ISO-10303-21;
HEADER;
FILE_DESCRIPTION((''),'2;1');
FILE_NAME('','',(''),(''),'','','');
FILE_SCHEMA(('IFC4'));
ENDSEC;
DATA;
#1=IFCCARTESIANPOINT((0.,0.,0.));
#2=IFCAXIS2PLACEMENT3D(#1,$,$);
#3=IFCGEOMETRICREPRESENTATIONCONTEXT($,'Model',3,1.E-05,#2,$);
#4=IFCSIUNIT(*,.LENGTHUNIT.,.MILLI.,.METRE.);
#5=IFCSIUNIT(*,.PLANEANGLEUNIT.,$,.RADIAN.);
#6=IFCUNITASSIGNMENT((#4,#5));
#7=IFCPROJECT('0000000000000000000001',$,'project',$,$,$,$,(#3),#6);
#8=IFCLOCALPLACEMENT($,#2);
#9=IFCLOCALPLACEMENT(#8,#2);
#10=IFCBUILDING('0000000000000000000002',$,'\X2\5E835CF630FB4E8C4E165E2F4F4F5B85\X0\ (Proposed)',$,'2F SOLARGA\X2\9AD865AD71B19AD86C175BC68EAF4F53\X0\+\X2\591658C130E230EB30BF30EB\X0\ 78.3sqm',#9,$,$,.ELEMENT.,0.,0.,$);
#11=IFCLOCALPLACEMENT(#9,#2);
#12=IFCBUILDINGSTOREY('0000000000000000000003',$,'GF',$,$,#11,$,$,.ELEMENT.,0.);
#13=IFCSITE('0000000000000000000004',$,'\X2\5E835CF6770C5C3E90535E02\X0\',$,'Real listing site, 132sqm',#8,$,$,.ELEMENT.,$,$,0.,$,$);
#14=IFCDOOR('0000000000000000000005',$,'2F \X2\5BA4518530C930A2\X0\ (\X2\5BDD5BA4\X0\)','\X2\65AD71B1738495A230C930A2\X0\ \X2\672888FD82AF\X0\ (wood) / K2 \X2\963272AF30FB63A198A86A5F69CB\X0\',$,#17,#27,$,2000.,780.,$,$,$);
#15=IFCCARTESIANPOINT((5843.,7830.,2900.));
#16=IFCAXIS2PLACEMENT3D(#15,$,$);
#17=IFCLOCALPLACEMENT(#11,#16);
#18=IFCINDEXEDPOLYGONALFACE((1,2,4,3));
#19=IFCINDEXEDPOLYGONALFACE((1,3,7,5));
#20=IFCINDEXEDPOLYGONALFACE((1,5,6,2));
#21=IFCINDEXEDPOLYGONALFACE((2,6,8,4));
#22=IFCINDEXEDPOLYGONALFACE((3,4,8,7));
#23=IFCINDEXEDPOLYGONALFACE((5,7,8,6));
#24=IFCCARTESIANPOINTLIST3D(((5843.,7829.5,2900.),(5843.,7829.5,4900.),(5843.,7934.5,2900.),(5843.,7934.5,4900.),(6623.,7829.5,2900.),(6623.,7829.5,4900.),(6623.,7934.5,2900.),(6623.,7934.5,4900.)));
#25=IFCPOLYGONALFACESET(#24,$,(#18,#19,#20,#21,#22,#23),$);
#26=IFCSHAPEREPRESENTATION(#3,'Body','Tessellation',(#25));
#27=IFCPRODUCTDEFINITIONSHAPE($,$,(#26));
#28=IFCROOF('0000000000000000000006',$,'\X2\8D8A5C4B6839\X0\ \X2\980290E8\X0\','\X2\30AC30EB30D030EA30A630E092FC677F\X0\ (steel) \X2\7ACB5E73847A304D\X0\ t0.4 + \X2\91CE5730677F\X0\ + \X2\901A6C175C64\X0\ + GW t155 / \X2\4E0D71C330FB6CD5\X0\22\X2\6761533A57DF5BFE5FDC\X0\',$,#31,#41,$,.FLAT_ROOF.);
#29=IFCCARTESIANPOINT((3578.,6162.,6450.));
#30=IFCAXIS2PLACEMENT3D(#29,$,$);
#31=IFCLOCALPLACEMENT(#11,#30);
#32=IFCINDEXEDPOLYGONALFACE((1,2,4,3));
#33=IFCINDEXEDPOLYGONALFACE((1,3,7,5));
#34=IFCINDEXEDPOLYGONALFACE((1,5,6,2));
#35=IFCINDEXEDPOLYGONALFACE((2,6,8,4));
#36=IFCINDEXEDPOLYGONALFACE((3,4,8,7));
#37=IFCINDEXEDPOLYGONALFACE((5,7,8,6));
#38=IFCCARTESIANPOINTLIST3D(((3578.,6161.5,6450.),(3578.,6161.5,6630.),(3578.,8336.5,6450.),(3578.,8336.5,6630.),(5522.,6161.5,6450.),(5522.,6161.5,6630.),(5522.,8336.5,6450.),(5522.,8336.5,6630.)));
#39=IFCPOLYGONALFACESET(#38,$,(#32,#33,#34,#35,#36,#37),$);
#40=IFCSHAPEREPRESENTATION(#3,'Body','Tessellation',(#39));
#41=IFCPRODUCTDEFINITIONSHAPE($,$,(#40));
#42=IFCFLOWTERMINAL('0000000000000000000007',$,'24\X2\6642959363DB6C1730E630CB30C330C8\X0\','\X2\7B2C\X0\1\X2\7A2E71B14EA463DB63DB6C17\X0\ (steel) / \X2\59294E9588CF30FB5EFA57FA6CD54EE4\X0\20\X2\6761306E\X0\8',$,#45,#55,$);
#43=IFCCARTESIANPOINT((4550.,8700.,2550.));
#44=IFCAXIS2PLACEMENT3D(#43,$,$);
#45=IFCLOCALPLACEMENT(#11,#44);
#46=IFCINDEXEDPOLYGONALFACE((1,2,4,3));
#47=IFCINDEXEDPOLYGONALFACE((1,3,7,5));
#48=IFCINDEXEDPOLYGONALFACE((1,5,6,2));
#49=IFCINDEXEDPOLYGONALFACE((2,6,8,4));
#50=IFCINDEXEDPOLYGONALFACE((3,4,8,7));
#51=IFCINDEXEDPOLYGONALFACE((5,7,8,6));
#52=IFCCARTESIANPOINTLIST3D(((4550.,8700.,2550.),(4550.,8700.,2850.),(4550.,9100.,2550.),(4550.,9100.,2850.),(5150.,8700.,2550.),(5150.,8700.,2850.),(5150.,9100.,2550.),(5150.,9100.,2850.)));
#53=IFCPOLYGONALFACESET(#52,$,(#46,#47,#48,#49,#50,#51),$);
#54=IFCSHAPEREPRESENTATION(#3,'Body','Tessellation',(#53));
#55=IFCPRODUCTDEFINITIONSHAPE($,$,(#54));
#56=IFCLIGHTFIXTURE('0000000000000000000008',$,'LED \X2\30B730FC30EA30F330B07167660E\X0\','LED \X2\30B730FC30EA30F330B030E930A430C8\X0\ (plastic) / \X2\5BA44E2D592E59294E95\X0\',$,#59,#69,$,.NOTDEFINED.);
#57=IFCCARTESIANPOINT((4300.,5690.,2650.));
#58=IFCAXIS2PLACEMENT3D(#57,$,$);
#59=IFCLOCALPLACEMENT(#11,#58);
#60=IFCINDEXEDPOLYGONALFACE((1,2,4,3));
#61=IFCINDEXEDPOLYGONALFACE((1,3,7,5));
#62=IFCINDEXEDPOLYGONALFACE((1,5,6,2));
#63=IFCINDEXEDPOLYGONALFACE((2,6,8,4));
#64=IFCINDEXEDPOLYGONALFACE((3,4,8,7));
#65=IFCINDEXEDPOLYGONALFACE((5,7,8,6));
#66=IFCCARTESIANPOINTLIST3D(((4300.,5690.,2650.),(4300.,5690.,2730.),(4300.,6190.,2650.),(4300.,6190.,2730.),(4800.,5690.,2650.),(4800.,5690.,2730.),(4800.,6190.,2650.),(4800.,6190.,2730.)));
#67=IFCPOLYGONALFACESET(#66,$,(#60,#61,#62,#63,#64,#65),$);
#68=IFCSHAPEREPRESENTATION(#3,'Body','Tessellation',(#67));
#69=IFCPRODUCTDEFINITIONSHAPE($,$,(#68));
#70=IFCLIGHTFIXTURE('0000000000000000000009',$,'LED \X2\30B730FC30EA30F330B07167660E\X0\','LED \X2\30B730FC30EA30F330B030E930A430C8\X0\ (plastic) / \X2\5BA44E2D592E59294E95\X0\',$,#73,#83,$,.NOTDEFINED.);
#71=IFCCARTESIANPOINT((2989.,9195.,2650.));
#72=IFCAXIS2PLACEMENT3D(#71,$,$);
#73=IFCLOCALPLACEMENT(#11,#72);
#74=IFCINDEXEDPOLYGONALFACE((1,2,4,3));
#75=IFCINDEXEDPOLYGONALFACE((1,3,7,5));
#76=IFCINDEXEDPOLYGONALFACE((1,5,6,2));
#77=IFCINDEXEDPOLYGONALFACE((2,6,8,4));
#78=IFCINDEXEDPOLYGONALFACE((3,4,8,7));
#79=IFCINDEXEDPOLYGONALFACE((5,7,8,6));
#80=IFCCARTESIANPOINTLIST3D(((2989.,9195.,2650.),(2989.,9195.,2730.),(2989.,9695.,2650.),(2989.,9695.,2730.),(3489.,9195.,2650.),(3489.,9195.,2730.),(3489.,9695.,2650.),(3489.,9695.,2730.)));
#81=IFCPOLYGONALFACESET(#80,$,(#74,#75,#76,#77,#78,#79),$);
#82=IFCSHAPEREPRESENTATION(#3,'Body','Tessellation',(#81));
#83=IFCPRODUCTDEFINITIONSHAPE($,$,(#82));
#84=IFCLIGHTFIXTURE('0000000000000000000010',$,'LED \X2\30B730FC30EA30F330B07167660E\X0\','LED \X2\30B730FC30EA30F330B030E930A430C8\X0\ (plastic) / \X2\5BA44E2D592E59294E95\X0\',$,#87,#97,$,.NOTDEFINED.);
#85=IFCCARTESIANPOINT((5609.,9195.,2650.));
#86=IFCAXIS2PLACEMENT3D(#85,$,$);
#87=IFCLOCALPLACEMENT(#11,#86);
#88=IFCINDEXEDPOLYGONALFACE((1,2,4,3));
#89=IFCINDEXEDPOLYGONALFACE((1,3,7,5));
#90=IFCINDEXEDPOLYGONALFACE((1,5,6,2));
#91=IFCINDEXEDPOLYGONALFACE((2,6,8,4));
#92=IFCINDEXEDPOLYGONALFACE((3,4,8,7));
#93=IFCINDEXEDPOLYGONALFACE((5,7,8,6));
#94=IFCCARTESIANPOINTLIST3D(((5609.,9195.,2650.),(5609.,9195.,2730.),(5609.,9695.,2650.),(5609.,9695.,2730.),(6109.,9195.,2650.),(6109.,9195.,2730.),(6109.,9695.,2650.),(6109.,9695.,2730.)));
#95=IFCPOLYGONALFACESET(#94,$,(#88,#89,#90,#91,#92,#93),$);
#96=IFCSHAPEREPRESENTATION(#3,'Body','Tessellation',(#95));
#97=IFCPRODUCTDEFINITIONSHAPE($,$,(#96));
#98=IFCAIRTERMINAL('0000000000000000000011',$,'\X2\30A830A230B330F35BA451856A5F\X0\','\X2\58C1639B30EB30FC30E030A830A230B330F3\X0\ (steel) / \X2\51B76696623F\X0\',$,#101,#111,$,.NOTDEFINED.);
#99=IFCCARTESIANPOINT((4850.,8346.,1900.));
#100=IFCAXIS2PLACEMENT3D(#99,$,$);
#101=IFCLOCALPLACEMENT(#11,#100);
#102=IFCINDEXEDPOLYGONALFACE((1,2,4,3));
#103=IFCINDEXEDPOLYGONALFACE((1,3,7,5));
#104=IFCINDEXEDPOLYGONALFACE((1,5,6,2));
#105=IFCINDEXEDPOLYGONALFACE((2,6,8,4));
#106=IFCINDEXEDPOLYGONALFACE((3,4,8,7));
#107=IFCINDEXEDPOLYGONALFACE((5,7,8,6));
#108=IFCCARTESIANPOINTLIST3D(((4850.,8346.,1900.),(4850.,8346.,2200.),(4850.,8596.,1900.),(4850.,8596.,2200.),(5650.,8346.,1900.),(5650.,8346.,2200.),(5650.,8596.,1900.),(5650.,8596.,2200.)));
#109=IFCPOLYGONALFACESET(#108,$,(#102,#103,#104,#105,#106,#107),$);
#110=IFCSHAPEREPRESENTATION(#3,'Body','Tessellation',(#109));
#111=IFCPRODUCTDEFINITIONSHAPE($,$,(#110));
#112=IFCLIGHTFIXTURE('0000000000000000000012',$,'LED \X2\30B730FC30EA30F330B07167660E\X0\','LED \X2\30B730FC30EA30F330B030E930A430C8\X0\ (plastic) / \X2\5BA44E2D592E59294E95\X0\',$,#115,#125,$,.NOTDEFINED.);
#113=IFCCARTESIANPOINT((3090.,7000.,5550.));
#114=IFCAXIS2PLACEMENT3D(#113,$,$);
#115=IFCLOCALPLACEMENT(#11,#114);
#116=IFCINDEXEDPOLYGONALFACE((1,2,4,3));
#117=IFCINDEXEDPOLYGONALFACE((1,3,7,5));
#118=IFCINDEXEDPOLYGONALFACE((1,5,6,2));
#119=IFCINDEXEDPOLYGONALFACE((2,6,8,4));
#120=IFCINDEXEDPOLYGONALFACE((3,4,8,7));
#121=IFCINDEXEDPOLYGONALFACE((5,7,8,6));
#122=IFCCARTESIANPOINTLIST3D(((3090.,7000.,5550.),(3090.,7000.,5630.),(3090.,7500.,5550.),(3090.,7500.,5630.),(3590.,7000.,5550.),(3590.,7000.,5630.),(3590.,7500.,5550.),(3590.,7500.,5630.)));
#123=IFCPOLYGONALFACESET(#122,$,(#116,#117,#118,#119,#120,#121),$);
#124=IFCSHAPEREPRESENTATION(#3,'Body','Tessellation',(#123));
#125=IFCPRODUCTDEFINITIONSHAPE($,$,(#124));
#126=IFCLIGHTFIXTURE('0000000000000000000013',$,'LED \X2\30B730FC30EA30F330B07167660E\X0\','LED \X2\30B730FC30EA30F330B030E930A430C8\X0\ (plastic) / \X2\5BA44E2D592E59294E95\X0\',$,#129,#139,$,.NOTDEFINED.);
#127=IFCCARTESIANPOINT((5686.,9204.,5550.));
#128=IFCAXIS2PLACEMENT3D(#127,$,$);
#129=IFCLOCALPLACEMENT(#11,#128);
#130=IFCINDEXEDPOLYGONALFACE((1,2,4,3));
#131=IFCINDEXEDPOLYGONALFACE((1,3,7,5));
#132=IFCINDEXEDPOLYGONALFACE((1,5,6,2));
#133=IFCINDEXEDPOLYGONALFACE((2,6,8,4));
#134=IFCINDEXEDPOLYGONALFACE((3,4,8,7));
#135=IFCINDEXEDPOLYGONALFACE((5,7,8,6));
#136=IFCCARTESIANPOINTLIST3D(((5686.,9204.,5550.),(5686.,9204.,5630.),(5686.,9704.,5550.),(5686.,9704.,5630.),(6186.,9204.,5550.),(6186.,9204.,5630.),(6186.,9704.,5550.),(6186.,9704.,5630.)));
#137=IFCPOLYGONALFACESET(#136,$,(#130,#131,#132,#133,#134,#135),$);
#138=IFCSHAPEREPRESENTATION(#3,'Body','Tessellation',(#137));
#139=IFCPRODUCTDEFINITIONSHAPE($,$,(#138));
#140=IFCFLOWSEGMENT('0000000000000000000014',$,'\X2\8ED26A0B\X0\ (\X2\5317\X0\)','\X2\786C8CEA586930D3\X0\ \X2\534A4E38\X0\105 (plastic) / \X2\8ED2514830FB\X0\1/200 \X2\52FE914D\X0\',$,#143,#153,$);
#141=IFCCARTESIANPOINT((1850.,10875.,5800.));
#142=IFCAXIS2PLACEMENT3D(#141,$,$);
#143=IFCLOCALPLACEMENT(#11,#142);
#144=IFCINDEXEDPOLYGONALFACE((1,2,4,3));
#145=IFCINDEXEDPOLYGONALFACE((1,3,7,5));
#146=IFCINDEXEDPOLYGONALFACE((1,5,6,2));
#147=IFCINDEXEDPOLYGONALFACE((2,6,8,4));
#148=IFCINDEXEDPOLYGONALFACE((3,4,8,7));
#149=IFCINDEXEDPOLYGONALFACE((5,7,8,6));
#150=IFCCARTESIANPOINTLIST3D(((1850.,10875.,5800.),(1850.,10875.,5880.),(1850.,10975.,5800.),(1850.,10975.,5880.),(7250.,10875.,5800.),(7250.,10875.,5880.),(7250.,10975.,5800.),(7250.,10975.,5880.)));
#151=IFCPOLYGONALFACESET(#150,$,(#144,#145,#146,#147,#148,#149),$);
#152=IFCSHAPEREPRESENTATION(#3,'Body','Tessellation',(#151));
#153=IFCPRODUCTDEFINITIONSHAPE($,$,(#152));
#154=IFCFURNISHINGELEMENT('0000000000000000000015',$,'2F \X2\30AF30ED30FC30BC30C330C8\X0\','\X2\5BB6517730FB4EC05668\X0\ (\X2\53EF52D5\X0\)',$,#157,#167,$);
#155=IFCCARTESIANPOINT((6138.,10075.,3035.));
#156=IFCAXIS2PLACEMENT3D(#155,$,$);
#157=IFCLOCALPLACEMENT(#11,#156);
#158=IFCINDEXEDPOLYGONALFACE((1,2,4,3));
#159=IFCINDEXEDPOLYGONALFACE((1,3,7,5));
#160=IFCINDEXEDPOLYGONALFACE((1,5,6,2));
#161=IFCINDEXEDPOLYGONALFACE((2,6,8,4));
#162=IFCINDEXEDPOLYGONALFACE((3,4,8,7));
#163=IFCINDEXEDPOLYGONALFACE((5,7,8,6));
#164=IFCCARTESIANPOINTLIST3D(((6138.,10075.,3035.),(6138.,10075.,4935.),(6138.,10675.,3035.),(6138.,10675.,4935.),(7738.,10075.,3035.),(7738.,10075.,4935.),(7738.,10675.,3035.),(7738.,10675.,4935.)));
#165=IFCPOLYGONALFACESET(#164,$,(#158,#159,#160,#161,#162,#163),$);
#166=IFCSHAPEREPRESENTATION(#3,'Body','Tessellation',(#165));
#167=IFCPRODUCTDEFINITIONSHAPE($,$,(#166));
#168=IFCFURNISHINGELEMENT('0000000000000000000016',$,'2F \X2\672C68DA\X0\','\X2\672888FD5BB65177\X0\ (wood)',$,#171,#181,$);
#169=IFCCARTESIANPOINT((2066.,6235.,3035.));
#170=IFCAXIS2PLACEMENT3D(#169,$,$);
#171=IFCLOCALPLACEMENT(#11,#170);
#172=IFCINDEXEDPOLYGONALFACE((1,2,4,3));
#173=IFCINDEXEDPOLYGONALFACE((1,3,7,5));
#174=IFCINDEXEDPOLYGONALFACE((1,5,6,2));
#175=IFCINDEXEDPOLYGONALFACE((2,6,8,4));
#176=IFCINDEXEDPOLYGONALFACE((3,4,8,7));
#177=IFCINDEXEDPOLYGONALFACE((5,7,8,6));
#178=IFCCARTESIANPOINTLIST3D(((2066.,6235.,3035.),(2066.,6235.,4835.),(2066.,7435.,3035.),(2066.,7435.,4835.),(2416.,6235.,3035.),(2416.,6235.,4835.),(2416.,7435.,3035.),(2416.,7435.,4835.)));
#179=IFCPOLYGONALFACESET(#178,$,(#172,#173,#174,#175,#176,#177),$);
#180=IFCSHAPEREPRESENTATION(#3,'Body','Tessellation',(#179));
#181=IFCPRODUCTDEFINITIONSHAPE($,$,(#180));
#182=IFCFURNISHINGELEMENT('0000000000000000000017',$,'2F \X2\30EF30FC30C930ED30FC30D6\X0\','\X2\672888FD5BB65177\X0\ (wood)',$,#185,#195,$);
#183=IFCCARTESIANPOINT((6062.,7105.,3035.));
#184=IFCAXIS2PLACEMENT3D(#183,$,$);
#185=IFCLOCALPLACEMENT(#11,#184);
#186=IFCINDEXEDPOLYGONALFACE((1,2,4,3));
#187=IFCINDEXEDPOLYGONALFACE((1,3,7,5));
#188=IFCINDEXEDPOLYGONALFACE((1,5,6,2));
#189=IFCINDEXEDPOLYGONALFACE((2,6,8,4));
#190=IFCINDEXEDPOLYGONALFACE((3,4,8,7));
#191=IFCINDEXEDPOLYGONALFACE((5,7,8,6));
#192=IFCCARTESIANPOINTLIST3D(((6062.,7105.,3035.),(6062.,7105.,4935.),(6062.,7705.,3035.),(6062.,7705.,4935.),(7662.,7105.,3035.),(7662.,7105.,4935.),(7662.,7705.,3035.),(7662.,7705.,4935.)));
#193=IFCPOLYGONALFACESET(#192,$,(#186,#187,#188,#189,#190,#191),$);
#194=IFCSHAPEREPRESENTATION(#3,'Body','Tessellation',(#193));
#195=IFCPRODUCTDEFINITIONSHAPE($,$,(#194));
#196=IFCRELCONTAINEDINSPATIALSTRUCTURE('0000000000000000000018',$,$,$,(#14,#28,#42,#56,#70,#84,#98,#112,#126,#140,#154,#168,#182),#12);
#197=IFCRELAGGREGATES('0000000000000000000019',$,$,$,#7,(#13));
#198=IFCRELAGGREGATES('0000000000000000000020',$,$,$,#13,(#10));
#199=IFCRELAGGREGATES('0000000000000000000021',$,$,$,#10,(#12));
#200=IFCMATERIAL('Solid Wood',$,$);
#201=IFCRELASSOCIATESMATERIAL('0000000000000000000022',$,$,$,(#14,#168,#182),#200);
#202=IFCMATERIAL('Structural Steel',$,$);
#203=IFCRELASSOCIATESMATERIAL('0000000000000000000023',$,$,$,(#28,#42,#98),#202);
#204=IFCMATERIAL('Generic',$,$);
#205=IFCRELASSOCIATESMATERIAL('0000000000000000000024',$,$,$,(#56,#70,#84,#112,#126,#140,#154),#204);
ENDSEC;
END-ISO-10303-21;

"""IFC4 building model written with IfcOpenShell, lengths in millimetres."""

from ifc_helpers import new_model, si_unit, frame, frame_2d, origin, place, context, project, spatial, rectangle, extrude, material, element, save


model = new_model("IFC4")

# Units and contexts
model_context = context("Model", 3, precision=1e-05, world=origin())
ifc_project = project(units=[si_unit("LENGTHUNIT", "METRE", prefix="MILLI"), si_unit("PLANEANGLEUNIT", "RADIAN")], contexts=[model_context])

# Site, building, storey
site_placement = place(None, origin())
site = spatial("IfcSite", under=ifc_project, at=site_placement, Name="広島県尾道市", ObjectType="Real listing site, 132sqm", CompositionType="ELEMENT", RefElevation=0.0)
building_placement = place(site_placement, origin())
building = spatial("IfcBuilding", under=site, at=building_placement, Name="広島・二世帯住宅 (Proposed)", ObjectType="2F SOLARGA高断熱高気密躯体+外壁モルタル 78.3sqm", CompositionType="ELEMENT", ElevationOfRefHeight=0.0, ElevationOfTerrain=0.0)
storey_placement = place(building_placement, origin())
storey = spatial("IfcBuildingStorey", under=building, at=storey_placement, Name="GF", CompositionType="ELEMENT", Elevation=0.0)

# Shared definitions
ifc_material_1 = material(Name="Solid Wood")

# Door
door_placement = place(storey_placement, frame((5843.0, 7830.0, 2900.0)))
element("IfcDoor", 1, at=door_placement, inside=storey, material=ifc_material_1, Name="2F 室内ドア (寝室)", Description="断熱玄関ドア 木製芯 (wood) / K2 防犯・採風機構", OverallHeight=2000.0, OverallWidth=780.0, context=model_context, shape_type="SweptSolid", body=[
    extrude(rectangle(XDim=780.0, YDim=105.0, at=frame_2d((390.0, 52.0))), frame((5843.0, 7830.0, 2900.0)), (0.0, 0.0, 1.0), 2000.0),
])

# Roof
ifc_material_2 = material(Name="Structural Steel")
roof_placement = place(storey_placement, frame((3578.0, 6162.0, 6450.0)))
element("IfcRoof", 2, at=roof_placement, inside=storey, material=ifc_material_2, Name="越屋根 頂部", Description="ガルバリウム鋼板 (steel) 立平葺き t0.4 + 野地板 + 通気層 + GW t155 / 不燃・法22条区域対応", PredefinedType="FLAT_ROOF", context=model_context, shape_type="SweptSolid", body=[
    extrude(rectangle(XDim=1944.0, YDim=2175.0, at=frame_2d((972.0, 1087.0))), frame((3578.0, 6162.0, 6450.0)), (0.0, 0.0, 1.0), 180.0),
])

# Flow terminal
flow_terminal_placement = place(storey_placement, frame((4550.0, 8700.0, 2550.0)))
element("IfcFlowTerminal", 3, at=flow_terminal_placement, inside=storey, material=ifc_material_2, Name="24時間換気ユニット", Description="第1種熱交換換気 (steel) / 天井裏・建基法令20条の8", context=model_context, shape_type="SweptSolid", body=[
    extrude(rectangle(XDim=600.0, YDim=400.0, at=frame_2d((300.0, 200.0))), frame((4550.0, 8700.0, 2550.0)), (0.0, 0.0, 1.0), 300.0),
])

# Light fixtures
ifc_material_3 = material(Name="Generic")
light_fixture_1_placement = place(storey_placement, frame((4300.0, 5690.0, 2650.0)))
element("IfcLightFixture", 4, at=light_fixture_1_placement, inside=storey, material=ifc_material_3, Name="LED シーリング照明", Description="LED シーリングライト (plastic) / 室中央天井", PredefinedType="NOTDEFINED", context=model_context, shape_type="SweptSolid", body=[
    extrude(rectangle(XDim=500.0, YDim=500.0, at=frame_2d((250.0, 250.0))), frame((4300.0, 5690.0, 2650.0)), (0.0, 0.0, 1.0), 80.0),
])
light_fixture_2_placement = place(storey_placement, frame((2989.0, 9195.0, 2650.0)))
element("IfcLightFixture", 5, at=light_fixture_2_placement, inside=storey, material=ifc_material_3, Name="LED シーリング照明", Description="LED シーリングライト (plastic) / 室中央天井", PredefinedType="NOTDEFINED", context=model_context, shape_type="SweptSolid", body=[
    extrude(rectangle(XDim=500.0, YDim=500.0, at=frame_2d((250.0, 250.0))), frame((2989.0, 9195.0, 2650.0)), (0.0, 0.0, 1.0), 80.0),
])
light_fixture_3_placement = place(storey_placement, frame((5609.0, 9195.0, 2650.0)))
element("IfcLightFixture", 6, at=light_fixture_3_placement, inside=storey, material=ifc_material_3, Name="LED シーリング照明", Description="LED シーリングライト (plastic) / 室中央天井", PredefinedType="NOTDEFINED", context=model_context, shape_type="SweptSolid", body=[
    extrude(rectangle(XDim=500.0, YDim=500.0, at=frame_2d((250.0, 250.0))), frame((5609.0, 9195.0, 2650.0)), (0.0, 0.0, 1.0), 80.0),
])

# Air terminal
air_terminal_placement = place(storey_placement, frame((4850.0, 8346.0, 1900.0)))
element("IfcAirTerminal", 7, at=air_terminal_placement, inside=storey, material=ifc_material_2, Name="エアコン室内機", Description="壁掛ルームエアコン (steel) / 冷暖房", PredefinedType="NOTDEFINED", context=model_context, shape_type="SweptSolid", body=[
    extrude(rectangle(XDim=800.0, YDim=250.0, at=frame_2d((400.0, 125.0))), frame((4850.0, 8346.0, 1900.0)), (0.0, 0.0, 1.0), 300.0),
])

# Light fixtures
light_fixture_4_placement = place(storey_placement, frame((3090.0, 7000.0, 5550.0)))
element("IfcLightFixture", 8, at=light_fixture_4_placement, inside=storey, material=ifc_material_3, Name="LED シーリング照明", Description="LED シーリングライト (plastic) / 室中央天井", PredefinedType="NOTDEFINED", context=model_context, shape_type="SweptSolid", body=[
    extrude(rectangle(XDim=500.0, YDim=500.0, at=frame_2d((250.0, 250.0))), frame((3090.0, 7000.0, 5550.0)), (0.0, 0.0, 1.0), 80.0),
])
light_fixture_5_placement = place(storey_placement, frame((5686.0, 9204.0, 5550.0)))
element("IfcLightFixture", 9, at=light_fixture_5_placement, inside=storey, material=ifc_material_3, Name="LED シーリング照明", Description="LED シーリングライト (plastic) / 室中央天井", PredefinedType="NOTDEFINED", context=model_context, shape_type="SweptSolid", body=[
    extrude(rectangle(XDim=500.0, YDim=500.0, at=frame_2d((250.0, 250.0))), frame((5686.0, 9204.0, 5550.0)), (0.0, 0.0, 1.0), 80.0),
])

# Flow segment
flow_segment_placement = place(storey_placement, frame((1850.0, 10875.0, 5800.0)))
element("IfcFlowSegment", 10, at=flow_segment_placement, inside=storey, material=ifc_material_3, Name="軒樋 (北)", Description="硬質塩ビ 半丸105 (plastic) / 軒先・1/200 勾配", context=model_context, shape_type="SweptSolid", body=[
    extrude(rectangle(XDim=5400.0, YDim=100.0, at=frame_2d((2700.0, 50.0))), frame((1850.0, 10875.0, 5800.0)), (0.0, 0.0, 1.0), 80.0),
])

# Furnishing elements
furnishing_1_placement = place(storey_placement, frame((6138.0, 10075.0, 3035.0)))
element("IfcFurnishingElement", 11, at=furnishing_1_placement, inside=storey, material=ifc_material_3, Name="2F クローゼット", Description="家具・什器 (可動)", context=model_context, shape_type="SweptSolid", body=[
    extrude(rectangle(XDim=1600.0, YDim=600.0, at=frame_2d((800.0, 300.0))), frame((6138.0, 10075.0, 3035.0)), (0.0, 0.0, 1.0), 1900.0),
])
furnishing_2_placement = place(storey_placement, frame((2066.0, 6235.0, 3035.0)))
element("IfcFurnishingElement", 12, at=furnishing_2_placement, inside=storey, material=ifc_material_1, Name="2F 本棚", Description="木製家具 (wood)", context=model_context, shape_type="SweptSolid", body=[
    extrude(rectangle(XDim=350.0, YDim=1200.0, at=frame_2d((175.0, 600.0))), frame((2066.0, 6235.0, 3035.0)), (0.0, 0.0, 1.0), 1800.0),
])
furnishing_3_placement = place(storey_placement, frame((6062.0, 7105.0, 3035.0)))
element("IfcFurnishingElement", 13, at=furnishing_3_placement, inside=storey, material=ifc_material_1, Name="2F ワードローブ", Description="木製家具 (wood)", context=model_context, shape_type="SweptSolid", body=[
    extrude(rectangle(XDim=1600.0, YDim=600.0, at=frame_2d((800.0, 300.0))), frame((6062.0, 7105.0, 3035.0)), (0.0, 0.0, 1.0), 1900.0),
])

save(model, "model.ifc")
